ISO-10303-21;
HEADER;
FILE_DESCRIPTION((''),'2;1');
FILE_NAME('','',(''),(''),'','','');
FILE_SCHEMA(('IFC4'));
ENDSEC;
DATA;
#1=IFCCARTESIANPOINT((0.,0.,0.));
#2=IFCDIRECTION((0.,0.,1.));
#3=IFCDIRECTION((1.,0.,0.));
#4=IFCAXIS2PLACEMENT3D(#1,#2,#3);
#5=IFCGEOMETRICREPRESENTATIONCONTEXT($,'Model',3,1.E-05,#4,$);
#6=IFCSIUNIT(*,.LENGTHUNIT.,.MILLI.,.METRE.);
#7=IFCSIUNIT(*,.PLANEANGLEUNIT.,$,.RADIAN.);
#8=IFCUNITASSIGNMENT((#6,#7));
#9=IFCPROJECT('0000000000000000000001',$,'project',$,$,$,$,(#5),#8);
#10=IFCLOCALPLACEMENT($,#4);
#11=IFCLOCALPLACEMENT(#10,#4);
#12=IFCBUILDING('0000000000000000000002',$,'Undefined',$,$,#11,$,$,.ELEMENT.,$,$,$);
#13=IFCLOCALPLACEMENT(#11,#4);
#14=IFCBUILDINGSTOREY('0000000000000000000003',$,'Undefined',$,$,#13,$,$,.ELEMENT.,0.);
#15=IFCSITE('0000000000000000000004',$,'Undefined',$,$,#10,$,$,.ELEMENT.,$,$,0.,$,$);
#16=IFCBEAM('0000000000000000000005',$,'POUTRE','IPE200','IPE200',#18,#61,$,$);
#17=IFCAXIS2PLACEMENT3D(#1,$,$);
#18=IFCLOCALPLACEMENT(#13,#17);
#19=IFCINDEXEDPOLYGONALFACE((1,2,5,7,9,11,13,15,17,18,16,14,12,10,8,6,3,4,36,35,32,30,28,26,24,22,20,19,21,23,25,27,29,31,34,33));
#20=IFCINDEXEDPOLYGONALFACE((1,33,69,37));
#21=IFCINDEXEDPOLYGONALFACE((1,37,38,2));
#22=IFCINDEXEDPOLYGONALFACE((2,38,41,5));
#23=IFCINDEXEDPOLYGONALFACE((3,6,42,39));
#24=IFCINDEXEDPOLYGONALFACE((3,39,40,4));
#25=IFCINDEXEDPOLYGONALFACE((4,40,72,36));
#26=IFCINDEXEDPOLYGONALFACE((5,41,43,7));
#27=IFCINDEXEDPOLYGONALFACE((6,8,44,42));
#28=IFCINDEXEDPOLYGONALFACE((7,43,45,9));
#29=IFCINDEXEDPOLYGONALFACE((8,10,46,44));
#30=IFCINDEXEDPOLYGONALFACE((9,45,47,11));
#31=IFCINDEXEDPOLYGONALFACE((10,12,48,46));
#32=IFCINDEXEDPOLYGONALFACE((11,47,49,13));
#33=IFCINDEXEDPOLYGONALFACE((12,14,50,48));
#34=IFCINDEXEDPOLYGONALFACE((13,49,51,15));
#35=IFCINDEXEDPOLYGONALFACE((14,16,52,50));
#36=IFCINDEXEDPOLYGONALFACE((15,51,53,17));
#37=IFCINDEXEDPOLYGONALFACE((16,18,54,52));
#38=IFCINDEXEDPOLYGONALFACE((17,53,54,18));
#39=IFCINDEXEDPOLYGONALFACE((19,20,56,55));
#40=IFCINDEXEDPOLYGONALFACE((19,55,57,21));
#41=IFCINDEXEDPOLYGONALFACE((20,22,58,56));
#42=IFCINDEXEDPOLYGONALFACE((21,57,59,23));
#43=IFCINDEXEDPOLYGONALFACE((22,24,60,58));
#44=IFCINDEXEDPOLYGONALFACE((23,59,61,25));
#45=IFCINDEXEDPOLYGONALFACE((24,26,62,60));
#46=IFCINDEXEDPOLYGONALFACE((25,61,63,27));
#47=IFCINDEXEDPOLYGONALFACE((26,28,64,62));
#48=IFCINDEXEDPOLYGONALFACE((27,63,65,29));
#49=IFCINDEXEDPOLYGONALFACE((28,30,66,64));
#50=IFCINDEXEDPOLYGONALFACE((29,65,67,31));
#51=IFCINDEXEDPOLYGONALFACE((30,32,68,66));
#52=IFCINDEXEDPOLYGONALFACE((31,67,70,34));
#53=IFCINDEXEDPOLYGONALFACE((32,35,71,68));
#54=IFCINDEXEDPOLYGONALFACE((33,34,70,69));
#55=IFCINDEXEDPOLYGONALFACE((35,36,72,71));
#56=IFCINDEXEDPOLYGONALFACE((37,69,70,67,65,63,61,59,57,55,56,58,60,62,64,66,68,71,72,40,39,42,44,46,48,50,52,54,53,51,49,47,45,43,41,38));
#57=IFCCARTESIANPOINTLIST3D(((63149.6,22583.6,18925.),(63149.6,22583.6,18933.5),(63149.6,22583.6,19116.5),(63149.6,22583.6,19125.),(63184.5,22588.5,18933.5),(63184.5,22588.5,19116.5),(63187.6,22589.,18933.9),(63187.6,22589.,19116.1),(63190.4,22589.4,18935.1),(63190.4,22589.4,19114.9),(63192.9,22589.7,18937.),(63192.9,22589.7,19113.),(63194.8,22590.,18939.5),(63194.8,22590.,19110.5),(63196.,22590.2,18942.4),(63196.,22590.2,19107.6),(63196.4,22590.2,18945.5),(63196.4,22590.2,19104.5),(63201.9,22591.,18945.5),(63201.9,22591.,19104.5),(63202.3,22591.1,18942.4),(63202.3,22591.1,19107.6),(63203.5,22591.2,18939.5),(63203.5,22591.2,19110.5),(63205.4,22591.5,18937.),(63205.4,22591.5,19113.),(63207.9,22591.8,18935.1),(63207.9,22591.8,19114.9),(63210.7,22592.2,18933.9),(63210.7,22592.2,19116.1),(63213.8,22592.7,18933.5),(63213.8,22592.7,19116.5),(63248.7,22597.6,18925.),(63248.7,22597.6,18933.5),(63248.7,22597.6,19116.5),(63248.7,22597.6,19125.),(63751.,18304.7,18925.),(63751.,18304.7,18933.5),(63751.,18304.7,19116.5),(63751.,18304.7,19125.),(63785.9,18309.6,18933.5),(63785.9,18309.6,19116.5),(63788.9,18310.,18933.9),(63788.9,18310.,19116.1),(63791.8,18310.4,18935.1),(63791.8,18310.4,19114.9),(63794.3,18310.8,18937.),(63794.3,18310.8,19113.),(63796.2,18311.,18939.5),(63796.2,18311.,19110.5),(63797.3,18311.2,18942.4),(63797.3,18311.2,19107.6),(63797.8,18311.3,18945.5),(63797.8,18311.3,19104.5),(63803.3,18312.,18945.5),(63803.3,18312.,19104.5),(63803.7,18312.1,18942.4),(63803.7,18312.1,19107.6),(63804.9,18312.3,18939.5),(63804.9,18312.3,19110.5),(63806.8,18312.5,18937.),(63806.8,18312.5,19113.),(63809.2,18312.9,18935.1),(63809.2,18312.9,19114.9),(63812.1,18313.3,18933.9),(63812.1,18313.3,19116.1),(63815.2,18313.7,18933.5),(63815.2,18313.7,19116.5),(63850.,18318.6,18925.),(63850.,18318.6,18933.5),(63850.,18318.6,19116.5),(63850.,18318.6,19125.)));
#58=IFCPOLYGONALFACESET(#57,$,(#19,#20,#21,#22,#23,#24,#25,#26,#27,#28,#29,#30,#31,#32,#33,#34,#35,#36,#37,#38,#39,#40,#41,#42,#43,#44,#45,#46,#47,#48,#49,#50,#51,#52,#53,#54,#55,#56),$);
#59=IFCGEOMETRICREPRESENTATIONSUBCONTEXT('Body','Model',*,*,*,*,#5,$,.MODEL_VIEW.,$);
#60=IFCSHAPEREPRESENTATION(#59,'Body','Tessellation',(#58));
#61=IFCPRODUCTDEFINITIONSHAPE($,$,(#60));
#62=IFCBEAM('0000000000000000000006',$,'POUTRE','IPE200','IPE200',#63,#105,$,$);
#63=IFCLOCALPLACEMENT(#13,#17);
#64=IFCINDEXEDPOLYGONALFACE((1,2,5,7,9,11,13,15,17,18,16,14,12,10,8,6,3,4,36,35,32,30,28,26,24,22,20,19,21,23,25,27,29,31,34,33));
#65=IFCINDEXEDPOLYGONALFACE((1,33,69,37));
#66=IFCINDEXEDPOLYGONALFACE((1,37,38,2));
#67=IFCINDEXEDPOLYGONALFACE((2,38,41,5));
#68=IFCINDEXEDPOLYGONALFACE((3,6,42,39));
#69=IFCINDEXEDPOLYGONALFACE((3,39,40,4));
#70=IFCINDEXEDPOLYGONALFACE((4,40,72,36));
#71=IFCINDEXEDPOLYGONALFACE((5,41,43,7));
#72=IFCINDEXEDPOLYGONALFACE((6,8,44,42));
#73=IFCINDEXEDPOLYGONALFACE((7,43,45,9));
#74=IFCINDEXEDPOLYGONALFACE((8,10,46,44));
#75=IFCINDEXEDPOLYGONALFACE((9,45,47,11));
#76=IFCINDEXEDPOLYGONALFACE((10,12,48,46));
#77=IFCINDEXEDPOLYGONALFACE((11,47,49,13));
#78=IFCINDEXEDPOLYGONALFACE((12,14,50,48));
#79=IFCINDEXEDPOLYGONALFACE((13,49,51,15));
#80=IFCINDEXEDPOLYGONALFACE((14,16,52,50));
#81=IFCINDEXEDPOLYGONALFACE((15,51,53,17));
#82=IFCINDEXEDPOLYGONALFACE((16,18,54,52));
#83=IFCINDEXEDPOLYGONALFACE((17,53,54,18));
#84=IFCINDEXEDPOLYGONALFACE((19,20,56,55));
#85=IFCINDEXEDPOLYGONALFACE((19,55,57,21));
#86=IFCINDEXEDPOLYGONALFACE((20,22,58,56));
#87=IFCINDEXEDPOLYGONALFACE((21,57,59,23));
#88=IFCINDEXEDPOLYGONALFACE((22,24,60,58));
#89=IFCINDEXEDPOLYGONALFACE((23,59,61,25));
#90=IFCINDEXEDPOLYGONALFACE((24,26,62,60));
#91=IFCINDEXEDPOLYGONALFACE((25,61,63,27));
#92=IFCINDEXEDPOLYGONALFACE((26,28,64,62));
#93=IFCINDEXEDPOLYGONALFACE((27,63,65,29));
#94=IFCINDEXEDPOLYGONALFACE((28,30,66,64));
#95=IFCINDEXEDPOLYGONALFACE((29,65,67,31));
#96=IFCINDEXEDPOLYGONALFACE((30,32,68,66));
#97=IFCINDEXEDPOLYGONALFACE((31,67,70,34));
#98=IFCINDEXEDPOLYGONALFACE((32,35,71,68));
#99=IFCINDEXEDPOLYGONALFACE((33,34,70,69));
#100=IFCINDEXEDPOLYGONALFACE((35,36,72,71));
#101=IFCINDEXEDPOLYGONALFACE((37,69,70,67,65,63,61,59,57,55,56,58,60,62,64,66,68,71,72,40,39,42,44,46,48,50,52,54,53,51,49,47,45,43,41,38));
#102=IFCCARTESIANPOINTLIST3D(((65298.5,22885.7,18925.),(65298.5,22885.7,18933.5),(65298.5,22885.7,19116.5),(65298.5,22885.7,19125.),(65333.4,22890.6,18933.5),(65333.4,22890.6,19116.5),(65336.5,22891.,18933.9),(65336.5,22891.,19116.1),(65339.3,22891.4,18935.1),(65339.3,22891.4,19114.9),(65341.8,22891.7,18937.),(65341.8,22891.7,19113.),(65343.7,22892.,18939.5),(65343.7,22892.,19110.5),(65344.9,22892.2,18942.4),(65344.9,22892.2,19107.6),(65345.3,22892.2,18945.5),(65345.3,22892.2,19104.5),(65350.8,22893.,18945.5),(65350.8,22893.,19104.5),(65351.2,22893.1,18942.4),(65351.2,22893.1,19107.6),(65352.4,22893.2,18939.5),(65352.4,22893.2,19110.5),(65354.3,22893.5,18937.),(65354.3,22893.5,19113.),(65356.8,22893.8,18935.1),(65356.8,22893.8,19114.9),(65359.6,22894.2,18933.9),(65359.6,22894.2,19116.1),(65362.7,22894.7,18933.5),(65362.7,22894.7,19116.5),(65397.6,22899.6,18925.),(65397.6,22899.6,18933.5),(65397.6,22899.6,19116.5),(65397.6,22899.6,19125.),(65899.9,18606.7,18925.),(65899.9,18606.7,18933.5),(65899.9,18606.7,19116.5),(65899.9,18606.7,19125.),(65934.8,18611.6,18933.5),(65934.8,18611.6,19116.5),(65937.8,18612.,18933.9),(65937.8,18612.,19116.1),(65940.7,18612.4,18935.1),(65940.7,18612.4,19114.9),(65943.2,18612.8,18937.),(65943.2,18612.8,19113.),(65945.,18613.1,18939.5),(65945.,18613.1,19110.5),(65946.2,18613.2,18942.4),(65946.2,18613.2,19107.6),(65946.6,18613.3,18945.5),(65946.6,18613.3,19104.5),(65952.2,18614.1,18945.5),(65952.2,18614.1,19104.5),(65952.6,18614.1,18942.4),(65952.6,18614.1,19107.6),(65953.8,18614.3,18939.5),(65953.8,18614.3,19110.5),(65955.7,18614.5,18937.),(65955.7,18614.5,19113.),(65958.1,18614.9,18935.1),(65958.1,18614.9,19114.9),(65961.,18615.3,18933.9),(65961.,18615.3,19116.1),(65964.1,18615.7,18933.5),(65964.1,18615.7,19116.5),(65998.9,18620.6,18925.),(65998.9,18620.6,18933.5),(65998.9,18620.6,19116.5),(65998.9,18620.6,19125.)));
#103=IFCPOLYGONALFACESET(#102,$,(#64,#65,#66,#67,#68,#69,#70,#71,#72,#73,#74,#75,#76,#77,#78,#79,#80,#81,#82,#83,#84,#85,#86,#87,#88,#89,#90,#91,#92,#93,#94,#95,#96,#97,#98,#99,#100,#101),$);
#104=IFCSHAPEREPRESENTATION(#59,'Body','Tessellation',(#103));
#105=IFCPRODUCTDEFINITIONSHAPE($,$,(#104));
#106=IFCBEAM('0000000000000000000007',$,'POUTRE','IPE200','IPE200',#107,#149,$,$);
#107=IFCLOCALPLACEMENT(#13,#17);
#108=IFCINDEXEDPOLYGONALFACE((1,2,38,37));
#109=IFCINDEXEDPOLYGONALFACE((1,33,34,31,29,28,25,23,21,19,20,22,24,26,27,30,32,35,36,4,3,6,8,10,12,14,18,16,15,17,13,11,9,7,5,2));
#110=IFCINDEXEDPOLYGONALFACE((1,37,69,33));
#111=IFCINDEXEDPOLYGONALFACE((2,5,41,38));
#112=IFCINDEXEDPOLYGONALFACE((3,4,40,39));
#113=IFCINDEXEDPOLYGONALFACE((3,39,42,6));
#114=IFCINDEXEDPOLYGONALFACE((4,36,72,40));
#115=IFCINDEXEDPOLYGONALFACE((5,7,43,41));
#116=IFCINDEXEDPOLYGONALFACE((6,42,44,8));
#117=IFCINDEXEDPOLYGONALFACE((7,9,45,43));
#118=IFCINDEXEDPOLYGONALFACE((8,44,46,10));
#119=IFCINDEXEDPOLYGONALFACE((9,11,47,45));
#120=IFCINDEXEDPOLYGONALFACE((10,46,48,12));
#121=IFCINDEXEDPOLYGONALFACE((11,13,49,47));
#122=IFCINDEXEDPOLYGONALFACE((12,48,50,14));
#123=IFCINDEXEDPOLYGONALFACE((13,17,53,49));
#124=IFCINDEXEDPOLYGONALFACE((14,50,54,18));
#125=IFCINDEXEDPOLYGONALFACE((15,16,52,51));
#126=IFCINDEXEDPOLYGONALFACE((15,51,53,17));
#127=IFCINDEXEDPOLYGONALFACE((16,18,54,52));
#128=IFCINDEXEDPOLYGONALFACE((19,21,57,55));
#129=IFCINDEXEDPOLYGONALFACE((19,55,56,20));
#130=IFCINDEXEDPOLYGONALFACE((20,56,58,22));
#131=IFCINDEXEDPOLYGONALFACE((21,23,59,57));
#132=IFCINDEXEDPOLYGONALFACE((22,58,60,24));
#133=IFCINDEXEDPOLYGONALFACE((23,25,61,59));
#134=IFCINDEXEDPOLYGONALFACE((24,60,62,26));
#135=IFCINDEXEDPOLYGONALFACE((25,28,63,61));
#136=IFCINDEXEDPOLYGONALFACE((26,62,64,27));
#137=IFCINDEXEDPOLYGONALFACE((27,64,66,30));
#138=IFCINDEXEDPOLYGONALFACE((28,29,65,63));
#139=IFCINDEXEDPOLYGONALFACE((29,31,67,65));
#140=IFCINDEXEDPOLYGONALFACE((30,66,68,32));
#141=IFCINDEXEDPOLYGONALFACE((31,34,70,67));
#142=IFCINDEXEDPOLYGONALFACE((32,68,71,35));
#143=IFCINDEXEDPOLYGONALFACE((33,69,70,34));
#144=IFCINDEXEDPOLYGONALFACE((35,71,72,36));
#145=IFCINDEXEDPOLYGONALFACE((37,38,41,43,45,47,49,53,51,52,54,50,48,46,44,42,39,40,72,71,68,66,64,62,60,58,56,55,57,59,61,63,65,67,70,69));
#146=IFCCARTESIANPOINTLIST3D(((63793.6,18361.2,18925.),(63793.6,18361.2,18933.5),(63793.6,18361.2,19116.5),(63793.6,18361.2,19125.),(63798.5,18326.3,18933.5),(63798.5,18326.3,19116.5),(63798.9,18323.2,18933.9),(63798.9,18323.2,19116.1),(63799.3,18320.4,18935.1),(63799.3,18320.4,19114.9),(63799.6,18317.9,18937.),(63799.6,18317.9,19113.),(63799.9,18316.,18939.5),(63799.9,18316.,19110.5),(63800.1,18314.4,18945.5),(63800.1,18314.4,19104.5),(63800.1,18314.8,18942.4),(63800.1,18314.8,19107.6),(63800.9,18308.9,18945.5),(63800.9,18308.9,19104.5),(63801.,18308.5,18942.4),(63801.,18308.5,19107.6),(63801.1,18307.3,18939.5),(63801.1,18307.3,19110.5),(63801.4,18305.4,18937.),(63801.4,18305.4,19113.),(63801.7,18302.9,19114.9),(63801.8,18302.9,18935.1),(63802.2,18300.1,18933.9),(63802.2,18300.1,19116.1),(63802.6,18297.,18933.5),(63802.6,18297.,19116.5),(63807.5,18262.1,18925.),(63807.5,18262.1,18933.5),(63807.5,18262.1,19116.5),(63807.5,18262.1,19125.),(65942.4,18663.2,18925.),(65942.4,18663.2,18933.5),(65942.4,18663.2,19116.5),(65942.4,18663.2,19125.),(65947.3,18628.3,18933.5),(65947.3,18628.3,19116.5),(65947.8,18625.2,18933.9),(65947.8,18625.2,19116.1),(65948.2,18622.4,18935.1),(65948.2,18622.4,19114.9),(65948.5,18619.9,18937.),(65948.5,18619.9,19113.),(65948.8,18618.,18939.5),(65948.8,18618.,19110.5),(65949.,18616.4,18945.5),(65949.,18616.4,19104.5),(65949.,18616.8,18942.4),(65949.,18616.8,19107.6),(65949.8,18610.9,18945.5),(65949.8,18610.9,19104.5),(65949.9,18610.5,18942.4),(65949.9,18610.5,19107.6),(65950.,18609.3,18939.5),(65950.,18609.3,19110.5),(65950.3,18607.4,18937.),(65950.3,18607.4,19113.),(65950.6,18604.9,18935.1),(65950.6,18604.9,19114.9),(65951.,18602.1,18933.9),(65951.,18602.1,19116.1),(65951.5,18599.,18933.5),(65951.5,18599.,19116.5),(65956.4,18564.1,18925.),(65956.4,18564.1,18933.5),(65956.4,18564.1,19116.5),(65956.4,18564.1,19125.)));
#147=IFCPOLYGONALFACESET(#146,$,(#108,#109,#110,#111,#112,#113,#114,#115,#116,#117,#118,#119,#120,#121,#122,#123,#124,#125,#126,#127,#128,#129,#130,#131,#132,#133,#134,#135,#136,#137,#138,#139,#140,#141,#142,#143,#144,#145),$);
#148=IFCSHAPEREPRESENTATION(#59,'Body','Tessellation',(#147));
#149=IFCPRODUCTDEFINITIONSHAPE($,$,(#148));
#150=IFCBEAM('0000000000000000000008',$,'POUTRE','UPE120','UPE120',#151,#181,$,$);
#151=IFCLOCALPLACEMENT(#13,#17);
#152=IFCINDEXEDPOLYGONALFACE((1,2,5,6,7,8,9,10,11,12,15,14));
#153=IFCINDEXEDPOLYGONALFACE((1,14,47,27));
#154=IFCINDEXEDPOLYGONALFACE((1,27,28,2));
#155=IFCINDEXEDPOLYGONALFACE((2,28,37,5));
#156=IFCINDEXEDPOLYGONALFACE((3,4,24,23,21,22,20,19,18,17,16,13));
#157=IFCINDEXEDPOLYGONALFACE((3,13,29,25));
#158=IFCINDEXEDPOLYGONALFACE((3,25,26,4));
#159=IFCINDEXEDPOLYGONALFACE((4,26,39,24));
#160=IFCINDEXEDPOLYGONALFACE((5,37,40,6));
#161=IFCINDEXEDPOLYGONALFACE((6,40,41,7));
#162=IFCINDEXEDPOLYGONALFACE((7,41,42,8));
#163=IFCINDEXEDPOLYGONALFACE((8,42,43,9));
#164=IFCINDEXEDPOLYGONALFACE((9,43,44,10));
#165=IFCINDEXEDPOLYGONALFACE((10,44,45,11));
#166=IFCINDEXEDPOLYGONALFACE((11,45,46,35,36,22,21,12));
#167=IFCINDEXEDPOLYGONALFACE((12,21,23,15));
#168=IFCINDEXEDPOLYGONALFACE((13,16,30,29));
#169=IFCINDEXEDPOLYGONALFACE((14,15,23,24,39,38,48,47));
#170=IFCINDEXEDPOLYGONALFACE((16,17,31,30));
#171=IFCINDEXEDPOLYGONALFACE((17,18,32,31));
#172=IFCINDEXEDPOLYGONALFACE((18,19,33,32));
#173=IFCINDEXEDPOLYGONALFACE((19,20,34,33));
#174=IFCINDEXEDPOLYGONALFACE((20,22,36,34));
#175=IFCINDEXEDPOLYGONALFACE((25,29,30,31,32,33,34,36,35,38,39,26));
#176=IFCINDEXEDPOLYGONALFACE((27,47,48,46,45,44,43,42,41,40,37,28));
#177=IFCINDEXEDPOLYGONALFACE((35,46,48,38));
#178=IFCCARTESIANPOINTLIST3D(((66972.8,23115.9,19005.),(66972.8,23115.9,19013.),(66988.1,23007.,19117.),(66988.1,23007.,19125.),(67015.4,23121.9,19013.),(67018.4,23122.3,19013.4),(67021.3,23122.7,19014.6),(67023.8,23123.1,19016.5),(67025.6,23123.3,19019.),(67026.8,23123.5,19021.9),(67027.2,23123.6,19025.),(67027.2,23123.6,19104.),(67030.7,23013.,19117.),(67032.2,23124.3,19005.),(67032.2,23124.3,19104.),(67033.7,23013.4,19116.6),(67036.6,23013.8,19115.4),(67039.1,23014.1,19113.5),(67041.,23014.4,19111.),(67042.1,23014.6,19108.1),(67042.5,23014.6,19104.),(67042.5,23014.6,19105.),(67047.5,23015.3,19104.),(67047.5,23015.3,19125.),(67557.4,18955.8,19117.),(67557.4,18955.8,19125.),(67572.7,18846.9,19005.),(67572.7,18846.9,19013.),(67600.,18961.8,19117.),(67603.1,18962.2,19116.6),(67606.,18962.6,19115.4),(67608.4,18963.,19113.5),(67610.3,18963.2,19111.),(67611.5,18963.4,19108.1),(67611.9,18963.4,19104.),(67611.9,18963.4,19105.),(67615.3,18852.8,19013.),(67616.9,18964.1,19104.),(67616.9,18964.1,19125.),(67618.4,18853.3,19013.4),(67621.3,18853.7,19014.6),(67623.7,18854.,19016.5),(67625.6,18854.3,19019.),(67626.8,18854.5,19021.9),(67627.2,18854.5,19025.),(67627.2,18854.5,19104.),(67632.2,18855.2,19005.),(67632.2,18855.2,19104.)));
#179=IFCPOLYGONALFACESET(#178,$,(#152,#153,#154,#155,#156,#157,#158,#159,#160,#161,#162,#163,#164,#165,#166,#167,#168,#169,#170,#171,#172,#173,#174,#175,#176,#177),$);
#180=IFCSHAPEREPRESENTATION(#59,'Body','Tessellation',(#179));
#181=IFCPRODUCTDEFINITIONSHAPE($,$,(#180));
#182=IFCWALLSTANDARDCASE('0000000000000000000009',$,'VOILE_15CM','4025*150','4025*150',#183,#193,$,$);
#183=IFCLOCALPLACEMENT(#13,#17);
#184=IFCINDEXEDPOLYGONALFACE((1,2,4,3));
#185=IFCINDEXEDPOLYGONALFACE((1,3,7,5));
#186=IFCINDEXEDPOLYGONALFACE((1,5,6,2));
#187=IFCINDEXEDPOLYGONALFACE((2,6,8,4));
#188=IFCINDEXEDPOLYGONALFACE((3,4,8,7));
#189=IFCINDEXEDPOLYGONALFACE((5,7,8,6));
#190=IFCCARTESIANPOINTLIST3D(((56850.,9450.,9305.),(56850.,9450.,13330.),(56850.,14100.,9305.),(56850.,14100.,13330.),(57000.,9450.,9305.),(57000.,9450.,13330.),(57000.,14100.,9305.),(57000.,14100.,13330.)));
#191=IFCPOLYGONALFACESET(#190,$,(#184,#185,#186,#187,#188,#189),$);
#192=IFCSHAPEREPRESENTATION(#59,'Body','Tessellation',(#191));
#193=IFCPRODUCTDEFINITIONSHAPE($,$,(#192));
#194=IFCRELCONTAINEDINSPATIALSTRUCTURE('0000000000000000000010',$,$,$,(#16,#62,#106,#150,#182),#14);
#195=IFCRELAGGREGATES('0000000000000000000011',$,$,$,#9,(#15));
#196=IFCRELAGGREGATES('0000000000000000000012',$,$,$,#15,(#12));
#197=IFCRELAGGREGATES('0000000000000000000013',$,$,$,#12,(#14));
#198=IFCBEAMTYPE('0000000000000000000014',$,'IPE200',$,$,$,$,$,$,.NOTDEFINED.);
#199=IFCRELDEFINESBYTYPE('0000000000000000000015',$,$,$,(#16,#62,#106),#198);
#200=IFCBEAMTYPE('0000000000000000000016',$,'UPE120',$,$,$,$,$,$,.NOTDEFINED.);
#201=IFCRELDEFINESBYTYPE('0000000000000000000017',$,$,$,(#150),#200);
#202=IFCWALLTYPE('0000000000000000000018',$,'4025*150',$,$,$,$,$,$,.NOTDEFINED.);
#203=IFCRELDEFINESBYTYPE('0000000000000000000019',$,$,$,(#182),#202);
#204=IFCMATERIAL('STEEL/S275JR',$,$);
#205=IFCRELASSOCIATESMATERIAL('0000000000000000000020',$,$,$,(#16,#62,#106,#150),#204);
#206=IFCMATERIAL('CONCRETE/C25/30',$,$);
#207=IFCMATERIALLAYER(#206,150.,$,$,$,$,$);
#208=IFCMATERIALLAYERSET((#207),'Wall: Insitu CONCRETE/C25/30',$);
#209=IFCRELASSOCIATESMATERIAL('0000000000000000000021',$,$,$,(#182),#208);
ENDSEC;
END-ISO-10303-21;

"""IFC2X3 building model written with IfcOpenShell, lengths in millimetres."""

from ifc_helpers import new_model, si_unit, frame, frame_2d, origin_with_axes, origin_2d_with_axis, place, context, subcontext, project, spatial, rectangle, i_section, u_section, extrude, boolean, material, layer, layer_set, layer_usage, type_object, element, save


model = new_model("IFC2X3")

# Units and contexts
model_context = context("Model", 3, precision=1e-05, world=origin_with_axes())
body_context = subcontext(model_context, "Body", "Model", "MODEL_VIEW")
ifc_project = project(units=[si_unit("LENGTHUNIT", "METRE", prefix="MILLI"), si_unit("PLANEANGLEUNIT", "RADIAN")], contexts=[model_context])

# Site, building, storey
site_placement = place(None, origin_with_axes())
site = spatial("IfcSite", under=ifc_project, at=site_placement, Name="Undefined", CompositionType="ELEMENT", RefElevation=0.0)
building_placement = place(site_placement, origin_with_axes())
building = spatial("IfcBuilding", under=site, at=building_placement, Name="Undefined", CompositionType="ELEMENT")
storey_placement = place(building_placement, origin_with_axes())
storey = spatial("IfcBuildingStorey", under=building, at=storey_placement, Name="Undefined", CompositionType="ELEMENT", Elevation=0.0)

# Shared definitions
ifc_material_1 = material(Name="CONCRETE/C25/30")
ifc_material_2 = material(Name="STEEL/S275JR")

# Beams
beam_type_1 = type_object("IfcBeamType", Name="IPE200", PredefinedType="NOTDEFINED")
beam_1_placement = place(storey_placement, frame((63800.5, 18311.7, 19025.0), z_axis=(0.0, 0.0, 1.0), x_axis=(-0.139172, 0.990268, 0.0)))
element("IfcBeam", 1, at=beam_1_placement, inside=storey, type_object=beam_type_1, material=ifc_material_2, Name="POUTRE", Description="IPE200", ObjectType="IPE200", context=body_context, shape_type="SweptSolid", body=[
    extrude(i_section(OverallWidth=100.0, OverallDepth=200.0, WebThickness=5.6, FlangeThickness=8.5, FilletRadius=12.0, at=origin_2d_with_axis()), frame((4321.0, 0.0, 0.0), z_axis=(-1.0, 0.0, 0.0), x_axis=(0.0, -1.0, 0.0)), (0.0, 0.0, 1.0), 4321.0),
])
beam_2_placement = place(storey_placement, frame((65949.4, 18613.7, 19025.0), z_axis=(0.0, 0.0, 1.0), x_axis=(-0.139172, 0.990268, 0.0)))
element("IfcBeam", 2, at=beam_2_placement, inside=storey, type_object=beam_type_1, material=ifc_material_2, Name="POUTRE", Description="IPE200", ObjectType="IPE200", context=body_context, shape_type="SweptSolid", body=[
    extrude(i_section(OverallWidth=100.0, OverallDepth=200.0, WebThickness=5.6, FlangeThickness=8.5, FilletRadius=12.0, at=origin_2d_with_axis()), frame((4321.0, 0.0, 0.0), z_axis=(-1.0, 0.0, 0.0), x_axis=(0.0, -1.0, 0.0)), (0.0, 0.0, 1.0), 4321.0),
])
beam_3_placement = place(storey_placement, frame((65949.4, 18613.7, 19025.0), z_axis=(-0.000014, -0.000002, 1.0), x_axis=(-0.990268, -0.139173, -0.000014)))
element("IfcBeam", 3, at=beam_3_placement, inside=storey, type_object=beam_type_1, material=ifc_material_2, Name="POUTRE", Description="IPE200", ObjectType="IPE200", context=body_context, shape_type="SweptSolid", body=[
    extrude(i_section(OverallWidth=100.0, OverallDepth=200.0, WebThickness=5.6, FlangeThickness=8.5, FilletRadius=12.0, at=origin_2d_with_axis()), frame((2170.0, 0.0, 0.0), z_axis=(-1.0, 0.0, 0.0), x_axis=(0.0, -1.0, 0.0)), (0.0, 0.0, 1.0), 2170.0),
])
beam_type_2 = type_object("IfcBeamType", Name="UPE120", PredefinedType="NOTDEFINED")
beam_4_placement = place(storey_placement, frame((67603.1, 18846.1, 19065.0), z_axis=(0.0, 0.0, -1.0), x_axis=(-0.139172, 0.990268, 0.0)))
element("IfcBeam", 4, at=beam_4_placement, inside=storey, type_object=beam_type_2, material=ifc_material_2, Name="POUTRE", Description="UPE120", ObjectType="UPE120", context=body_context, shape_type="CSG", body=[
    boolean("DIFFERENCE", boolean("DIFFERENCE", extrude(u_section(Depth=120.0, FlangeWidth=60.0, WebThickness=5.0, FlangeThickness=8.0, FilletRadius=12.0, at=origin_2d_with_axis()), frame((4316.0, 0.0, 0.0), z_axis=(-1.0, 0.0, 0.0), x_axis=(0.0, -1.0, 0.0)), (0.0, 0.0, 1.0), 4311.0), extrude(rectangle(XDim=22.0, YDim=112.0, at=origin_2d_with_axis()), frame((4262.0, -31.0, -50.0), z_axis=(0.000005, 1.0, 0.0), x_axis=(0.0, 0.0, 1.0)), (0.0, 0.0, 1.0), 62.0)), extrude(rectangle(XDim=22.0, YDim=112.0, at=origin_2d_with_axis()), frame((59.0, 31.0, -50.0), z_axis=(-0.000005, -1.0, 0.0), x_axis=(0.0, 0.0, 1.0)), (0.0, 0.0, 1.0), 62.0)),
])

# Wall
wall_type_1 = type_object("IfcWallType", Name="4025*150", PredefinedType="NOTDEFINED")
ifc_layer_1 = layer(ifc_material_1, 150.0)
ifc_layer_set_1 = layer_set([ifc_layer_1], Name="Wall: Insitu CONCRETE/C25/30")
ifc_layer_usage_1 = layer_usage(ifc_layer_set_1, "AXIS2", "POSITIVE", -75.0)
wall_1_placement = place(storey_placement, frame((56925.0, 14100.0, 9305.0), z_axis=(0.0, 0.0, 1.0), x_axis=(0.0, -1.0, 0.0)))
element("IfcWallStandardCase", 5, at=wall_1_placement, inside=storey, type_object=wall_type_1, material=ifc_layer_usage_1, Name="VOILE_15CM", Description="4025*150", ObjectType="4025*150", context=body_context, shape_type="SweptSolid", body=[
    extrude(rectangle(XDim=4650.0, YDim=150.0, at=frame_2d((0.0, 2325.0), x_axis=(0.0, -1.0))), frame((0.0, 0.0, 0.0), z_axis=(0.0, 0.0, 1.0), x_axis=(0.0, -1.0, 0.0)), (0.0, 0.0, 1.0), 4025.0),
])

save(model, "model.ifc")
